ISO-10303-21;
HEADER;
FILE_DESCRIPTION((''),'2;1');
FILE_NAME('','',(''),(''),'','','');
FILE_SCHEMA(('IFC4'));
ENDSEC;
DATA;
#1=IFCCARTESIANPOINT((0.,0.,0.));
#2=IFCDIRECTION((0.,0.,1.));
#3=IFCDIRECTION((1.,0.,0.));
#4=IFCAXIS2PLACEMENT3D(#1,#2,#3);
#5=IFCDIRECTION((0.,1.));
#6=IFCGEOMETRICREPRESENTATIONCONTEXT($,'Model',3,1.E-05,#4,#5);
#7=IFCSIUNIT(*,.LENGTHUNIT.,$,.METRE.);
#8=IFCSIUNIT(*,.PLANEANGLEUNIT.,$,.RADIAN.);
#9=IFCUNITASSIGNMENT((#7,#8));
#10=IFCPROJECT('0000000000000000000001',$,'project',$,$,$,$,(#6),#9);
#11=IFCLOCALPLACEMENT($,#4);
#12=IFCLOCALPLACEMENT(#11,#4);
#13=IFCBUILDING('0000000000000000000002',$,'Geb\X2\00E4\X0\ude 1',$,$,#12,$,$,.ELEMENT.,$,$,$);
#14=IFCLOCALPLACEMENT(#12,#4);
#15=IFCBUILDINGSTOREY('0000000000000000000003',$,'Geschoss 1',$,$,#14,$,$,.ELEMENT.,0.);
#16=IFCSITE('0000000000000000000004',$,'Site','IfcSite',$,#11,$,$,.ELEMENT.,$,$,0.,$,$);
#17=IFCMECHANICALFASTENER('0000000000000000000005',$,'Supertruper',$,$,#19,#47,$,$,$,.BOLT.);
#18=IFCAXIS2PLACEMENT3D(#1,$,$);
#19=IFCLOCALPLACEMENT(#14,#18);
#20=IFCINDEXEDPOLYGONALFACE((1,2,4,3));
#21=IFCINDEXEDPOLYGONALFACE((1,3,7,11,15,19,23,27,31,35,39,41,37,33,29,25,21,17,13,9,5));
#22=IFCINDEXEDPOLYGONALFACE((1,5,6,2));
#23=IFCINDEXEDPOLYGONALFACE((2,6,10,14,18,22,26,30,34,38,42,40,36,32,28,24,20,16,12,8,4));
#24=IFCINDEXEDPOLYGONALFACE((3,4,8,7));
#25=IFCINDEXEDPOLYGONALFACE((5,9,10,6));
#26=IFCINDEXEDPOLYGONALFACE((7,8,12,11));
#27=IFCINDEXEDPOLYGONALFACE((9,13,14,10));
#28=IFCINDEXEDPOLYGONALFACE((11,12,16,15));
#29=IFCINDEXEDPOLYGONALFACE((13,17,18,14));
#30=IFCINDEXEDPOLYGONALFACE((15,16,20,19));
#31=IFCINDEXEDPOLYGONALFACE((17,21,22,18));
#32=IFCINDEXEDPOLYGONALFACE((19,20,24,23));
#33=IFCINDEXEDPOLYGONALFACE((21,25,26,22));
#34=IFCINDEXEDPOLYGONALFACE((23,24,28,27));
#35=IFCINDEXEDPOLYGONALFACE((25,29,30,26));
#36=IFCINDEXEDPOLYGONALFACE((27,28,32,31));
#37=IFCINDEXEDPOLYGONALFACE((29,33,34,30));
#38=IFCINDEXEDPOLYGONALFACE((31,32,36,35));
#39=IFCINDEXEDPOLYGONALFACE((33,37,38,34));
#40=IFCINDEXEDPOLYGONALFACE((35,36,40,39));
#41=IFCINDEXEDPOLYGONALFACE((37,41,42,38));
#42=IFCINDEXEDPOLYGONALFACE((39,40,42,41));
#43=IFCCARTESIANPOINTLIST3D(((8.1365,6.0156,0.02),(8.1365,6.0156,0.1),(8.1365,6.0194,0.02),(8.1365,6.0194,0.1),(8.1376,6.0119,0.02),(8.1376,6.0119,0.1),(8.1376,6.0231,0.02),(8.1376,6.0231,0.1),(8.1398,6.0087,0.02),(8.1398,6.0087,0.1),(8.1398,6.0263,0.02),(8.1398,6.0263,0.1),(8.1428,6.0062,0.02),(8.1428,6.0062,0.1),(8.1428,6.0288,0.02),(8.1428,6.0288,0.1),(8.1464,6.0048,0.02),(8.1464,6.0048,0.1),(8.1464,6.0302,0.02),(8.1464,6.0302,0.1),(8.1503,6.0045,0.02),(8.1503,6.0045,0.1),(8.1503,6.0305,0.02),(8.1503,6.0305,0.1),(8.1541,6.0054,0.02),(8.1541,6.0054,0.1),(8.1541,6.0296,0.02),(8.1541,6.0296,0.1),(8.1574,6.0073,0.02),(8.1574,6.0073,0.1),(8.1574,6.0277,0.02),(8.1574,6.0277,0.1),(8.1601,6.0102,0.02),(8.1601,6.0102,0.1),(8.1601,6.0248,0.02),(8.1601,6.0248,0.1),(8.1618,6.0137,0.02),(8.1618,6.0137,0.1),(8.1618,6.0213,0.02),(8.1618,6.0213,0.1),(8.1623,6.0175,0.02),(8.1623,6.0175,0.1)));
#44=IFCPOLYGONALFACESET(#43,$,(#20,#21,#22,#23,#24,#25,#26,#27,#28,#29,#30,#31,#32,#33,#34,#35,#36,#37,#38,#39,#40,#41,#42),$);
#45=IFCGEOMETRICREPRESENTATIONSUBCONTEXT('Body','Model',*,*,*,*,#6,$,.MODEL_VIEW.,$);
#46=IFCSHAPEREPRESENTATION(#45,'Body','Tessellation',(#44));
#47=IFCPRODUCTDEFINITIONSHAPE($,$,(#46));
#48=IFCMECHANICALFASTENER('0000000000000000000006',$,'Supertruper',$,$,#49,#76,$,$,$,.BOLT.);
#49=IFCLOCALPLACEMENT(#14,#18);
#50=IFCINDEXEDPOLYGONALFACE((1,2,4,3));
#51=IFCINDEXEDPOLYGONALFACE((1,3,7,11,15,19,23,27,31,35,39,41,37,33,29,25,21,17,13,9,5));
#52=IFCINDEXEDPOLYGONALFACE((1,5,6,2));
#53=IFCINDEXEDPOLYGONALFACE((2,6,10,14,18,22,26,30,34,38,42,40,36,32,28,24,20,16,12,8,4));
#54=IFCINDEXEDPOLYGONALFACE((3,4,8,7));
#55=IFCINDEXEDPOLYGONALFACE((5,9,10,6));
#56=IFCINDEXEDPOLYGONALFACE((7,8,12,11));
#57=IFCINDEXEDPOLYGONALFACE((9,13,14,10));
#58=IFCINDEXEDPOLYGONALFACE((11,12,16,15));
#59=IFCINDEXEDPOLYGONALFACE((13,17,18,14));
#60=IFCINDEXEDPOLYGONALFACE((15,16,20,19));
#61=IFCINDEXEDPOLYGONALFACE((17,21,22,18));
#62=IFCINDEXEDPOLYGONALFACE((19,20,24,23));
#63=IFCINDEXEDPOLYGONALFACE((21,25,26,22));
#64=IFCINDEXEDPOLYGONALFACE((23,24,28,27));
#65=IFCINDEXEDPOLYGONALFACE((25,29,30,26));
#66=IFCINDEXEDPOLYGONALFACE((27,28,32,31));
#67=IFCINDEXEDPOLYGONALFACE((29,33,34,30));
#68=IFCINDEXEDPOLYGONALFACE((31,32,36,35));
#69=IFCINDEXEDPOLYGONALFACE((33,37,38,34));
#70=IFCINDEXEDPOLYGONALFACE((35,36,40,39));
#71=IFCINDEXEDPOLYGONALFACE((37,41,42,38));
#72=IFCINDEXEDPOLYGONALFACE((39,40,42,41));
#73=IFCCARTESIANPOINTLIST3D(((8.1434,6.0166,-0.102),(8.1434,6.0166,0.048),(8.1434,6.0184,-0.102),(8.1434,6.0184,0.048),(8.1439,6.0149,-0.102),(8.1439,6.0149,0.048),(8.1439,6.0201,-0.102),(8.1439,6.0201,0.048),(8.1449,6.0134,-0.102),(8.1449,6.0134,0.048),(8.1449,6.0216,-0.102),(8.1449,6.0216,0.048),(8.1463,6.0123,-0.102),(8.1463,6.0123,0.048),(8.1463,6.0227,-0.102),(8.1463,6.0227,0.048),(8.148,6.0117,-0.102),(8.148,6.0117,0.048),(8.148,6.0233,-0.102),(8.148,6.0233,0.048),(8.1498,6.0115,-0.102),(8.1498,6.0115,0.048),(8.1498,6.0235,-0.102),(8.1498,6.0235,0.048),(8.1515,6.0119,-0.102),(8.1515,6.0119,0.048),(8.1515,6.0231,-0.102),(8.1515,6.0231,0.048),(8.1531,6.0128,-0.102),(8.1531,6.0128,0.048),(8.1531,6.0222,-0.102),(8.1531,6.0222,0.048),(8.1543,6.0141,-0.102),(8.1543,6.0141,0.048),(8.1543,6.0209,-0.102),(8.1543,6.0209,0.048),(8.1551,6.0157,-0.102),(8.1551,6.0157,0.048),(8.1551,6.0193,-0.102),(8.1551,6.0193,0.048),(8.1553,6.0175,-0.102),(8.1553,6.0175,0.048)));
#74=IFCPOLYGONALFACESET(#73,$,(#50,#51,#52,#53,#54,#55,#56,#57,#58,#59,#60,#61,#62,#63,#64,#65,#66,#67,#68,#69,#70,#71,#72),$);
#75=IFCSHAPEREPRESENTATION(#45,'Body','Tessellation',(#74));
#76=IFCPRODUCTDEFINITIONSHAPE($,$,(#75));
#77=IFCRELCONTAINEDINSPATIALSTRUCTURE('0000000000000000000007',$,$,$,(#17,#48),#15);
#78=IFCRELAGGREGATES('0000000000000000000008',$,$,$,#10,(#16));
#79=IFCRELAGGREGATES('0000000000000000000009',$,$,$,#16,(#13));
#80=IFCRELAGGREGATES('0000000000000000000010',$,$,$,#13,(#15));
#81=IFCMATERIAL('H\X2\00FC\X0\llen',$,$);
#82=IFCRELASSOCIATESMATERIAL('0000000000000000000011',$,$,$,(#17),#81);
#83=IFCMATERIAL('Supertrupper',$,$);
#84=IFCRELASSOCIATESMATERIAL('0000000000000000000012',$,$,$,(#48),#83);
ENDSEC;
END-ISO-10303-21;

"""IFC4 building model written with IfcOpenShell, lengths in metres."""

from ifc_helpers import new_model, si_unit, direction, frame, origin_with_axes, origin_2d_with_axis, place, context, subcontext, project, spatial, circle, extrude, material, element, save


model = new_model("IFC4")

# Units and contexts
model_context = context("Model", 3, precision=1e-05, world=origin_with_axes(), true_north=direction((0.0, 1.0)))
body_context = subcontext(model_context, "Body", "Model", "MODEL_VIEW")
ifc_project = project(units=[si_unit("LENGTHUNIT", "METRE"), si_unit("PLANEANGLEUNIT", "RADIAN")], contexts=[model_context])

# Site, building, storey
site_placement = place(None, origin_with_axes())
site = spatial("IfcSite", under=ifc_project, at=site_placement, Name="Site", Description="IfcSite", CompositionType="ELEMENT", RefElevation=0.0)
building_placement = place(site_placement, origin_with_axes())
building = spatial("IfcBuilding", under=site, at=building_placement, Name="Gebäude 1", CompositionType="ELEMENT")
storey_placement = place(building_placement, origin_with_axes())
storey = spatial("IfcBuildingStorey", under=building, at=storey_placement, Name="Geschoss 1", CompositionType="ELEMENT", Elevation=0.0)

# Mechanical fasteners
ifc_material_1 = material(Name="Hüllen")
mechanical_fastener_1_placement = place(storey_placement, frame((8.1493, 6.0175, 0.1), z_axis=(0.0, -1.0, 0.0), x_axis=(0.0, 0.0, -1.0)))
element("IfcMechanicalFastener", 1, at=mechanical_fastener_1_placement, inside=storey, material=ifc_material_1, Name="Supertruper", PredefinedType="BOLT", context=body_context, shape_type="SweptSolid", body=[
    extrude(circle(Radius=0.013, at=origin_2d_with_axis()), frame((0.0, 0.0, 0.0), z_axis=(1.0, 0.0, 0.0), x_axis=(0.0, 1.0, 0.0)), (0.0, 0.0, 1.0), 0.08),
])
ifc_material_2 = material(Name="Supertrupper")
mechanical_fastener_2_placement = place(storey_placement, frame((8.1493, 6.0175, 0.048), z_axis=(0.0, -1.0, 0.0), x_axis=(0.0, 0.0, -1.0)))
element("IfcMechanicalFastener", 2, at=mechanical_fastener_2_placement, inside=storey, material=ifc_material_2, Name="Supertruper", PredefinedType="BOLT", context=body_context, shape_type="SweptSolid", body=[
    extrude(circle(Radius=0.006, at=origin_2d_with_axis()), frame((0.0, 0.0, 0.0), z_axis=(1.0, 0.0, 0.0), x_axis=(0.0, 1.0, 0.0)), (0.0, 0.0, 1.0), 0.15),
])

save(model, "model.ifc")
